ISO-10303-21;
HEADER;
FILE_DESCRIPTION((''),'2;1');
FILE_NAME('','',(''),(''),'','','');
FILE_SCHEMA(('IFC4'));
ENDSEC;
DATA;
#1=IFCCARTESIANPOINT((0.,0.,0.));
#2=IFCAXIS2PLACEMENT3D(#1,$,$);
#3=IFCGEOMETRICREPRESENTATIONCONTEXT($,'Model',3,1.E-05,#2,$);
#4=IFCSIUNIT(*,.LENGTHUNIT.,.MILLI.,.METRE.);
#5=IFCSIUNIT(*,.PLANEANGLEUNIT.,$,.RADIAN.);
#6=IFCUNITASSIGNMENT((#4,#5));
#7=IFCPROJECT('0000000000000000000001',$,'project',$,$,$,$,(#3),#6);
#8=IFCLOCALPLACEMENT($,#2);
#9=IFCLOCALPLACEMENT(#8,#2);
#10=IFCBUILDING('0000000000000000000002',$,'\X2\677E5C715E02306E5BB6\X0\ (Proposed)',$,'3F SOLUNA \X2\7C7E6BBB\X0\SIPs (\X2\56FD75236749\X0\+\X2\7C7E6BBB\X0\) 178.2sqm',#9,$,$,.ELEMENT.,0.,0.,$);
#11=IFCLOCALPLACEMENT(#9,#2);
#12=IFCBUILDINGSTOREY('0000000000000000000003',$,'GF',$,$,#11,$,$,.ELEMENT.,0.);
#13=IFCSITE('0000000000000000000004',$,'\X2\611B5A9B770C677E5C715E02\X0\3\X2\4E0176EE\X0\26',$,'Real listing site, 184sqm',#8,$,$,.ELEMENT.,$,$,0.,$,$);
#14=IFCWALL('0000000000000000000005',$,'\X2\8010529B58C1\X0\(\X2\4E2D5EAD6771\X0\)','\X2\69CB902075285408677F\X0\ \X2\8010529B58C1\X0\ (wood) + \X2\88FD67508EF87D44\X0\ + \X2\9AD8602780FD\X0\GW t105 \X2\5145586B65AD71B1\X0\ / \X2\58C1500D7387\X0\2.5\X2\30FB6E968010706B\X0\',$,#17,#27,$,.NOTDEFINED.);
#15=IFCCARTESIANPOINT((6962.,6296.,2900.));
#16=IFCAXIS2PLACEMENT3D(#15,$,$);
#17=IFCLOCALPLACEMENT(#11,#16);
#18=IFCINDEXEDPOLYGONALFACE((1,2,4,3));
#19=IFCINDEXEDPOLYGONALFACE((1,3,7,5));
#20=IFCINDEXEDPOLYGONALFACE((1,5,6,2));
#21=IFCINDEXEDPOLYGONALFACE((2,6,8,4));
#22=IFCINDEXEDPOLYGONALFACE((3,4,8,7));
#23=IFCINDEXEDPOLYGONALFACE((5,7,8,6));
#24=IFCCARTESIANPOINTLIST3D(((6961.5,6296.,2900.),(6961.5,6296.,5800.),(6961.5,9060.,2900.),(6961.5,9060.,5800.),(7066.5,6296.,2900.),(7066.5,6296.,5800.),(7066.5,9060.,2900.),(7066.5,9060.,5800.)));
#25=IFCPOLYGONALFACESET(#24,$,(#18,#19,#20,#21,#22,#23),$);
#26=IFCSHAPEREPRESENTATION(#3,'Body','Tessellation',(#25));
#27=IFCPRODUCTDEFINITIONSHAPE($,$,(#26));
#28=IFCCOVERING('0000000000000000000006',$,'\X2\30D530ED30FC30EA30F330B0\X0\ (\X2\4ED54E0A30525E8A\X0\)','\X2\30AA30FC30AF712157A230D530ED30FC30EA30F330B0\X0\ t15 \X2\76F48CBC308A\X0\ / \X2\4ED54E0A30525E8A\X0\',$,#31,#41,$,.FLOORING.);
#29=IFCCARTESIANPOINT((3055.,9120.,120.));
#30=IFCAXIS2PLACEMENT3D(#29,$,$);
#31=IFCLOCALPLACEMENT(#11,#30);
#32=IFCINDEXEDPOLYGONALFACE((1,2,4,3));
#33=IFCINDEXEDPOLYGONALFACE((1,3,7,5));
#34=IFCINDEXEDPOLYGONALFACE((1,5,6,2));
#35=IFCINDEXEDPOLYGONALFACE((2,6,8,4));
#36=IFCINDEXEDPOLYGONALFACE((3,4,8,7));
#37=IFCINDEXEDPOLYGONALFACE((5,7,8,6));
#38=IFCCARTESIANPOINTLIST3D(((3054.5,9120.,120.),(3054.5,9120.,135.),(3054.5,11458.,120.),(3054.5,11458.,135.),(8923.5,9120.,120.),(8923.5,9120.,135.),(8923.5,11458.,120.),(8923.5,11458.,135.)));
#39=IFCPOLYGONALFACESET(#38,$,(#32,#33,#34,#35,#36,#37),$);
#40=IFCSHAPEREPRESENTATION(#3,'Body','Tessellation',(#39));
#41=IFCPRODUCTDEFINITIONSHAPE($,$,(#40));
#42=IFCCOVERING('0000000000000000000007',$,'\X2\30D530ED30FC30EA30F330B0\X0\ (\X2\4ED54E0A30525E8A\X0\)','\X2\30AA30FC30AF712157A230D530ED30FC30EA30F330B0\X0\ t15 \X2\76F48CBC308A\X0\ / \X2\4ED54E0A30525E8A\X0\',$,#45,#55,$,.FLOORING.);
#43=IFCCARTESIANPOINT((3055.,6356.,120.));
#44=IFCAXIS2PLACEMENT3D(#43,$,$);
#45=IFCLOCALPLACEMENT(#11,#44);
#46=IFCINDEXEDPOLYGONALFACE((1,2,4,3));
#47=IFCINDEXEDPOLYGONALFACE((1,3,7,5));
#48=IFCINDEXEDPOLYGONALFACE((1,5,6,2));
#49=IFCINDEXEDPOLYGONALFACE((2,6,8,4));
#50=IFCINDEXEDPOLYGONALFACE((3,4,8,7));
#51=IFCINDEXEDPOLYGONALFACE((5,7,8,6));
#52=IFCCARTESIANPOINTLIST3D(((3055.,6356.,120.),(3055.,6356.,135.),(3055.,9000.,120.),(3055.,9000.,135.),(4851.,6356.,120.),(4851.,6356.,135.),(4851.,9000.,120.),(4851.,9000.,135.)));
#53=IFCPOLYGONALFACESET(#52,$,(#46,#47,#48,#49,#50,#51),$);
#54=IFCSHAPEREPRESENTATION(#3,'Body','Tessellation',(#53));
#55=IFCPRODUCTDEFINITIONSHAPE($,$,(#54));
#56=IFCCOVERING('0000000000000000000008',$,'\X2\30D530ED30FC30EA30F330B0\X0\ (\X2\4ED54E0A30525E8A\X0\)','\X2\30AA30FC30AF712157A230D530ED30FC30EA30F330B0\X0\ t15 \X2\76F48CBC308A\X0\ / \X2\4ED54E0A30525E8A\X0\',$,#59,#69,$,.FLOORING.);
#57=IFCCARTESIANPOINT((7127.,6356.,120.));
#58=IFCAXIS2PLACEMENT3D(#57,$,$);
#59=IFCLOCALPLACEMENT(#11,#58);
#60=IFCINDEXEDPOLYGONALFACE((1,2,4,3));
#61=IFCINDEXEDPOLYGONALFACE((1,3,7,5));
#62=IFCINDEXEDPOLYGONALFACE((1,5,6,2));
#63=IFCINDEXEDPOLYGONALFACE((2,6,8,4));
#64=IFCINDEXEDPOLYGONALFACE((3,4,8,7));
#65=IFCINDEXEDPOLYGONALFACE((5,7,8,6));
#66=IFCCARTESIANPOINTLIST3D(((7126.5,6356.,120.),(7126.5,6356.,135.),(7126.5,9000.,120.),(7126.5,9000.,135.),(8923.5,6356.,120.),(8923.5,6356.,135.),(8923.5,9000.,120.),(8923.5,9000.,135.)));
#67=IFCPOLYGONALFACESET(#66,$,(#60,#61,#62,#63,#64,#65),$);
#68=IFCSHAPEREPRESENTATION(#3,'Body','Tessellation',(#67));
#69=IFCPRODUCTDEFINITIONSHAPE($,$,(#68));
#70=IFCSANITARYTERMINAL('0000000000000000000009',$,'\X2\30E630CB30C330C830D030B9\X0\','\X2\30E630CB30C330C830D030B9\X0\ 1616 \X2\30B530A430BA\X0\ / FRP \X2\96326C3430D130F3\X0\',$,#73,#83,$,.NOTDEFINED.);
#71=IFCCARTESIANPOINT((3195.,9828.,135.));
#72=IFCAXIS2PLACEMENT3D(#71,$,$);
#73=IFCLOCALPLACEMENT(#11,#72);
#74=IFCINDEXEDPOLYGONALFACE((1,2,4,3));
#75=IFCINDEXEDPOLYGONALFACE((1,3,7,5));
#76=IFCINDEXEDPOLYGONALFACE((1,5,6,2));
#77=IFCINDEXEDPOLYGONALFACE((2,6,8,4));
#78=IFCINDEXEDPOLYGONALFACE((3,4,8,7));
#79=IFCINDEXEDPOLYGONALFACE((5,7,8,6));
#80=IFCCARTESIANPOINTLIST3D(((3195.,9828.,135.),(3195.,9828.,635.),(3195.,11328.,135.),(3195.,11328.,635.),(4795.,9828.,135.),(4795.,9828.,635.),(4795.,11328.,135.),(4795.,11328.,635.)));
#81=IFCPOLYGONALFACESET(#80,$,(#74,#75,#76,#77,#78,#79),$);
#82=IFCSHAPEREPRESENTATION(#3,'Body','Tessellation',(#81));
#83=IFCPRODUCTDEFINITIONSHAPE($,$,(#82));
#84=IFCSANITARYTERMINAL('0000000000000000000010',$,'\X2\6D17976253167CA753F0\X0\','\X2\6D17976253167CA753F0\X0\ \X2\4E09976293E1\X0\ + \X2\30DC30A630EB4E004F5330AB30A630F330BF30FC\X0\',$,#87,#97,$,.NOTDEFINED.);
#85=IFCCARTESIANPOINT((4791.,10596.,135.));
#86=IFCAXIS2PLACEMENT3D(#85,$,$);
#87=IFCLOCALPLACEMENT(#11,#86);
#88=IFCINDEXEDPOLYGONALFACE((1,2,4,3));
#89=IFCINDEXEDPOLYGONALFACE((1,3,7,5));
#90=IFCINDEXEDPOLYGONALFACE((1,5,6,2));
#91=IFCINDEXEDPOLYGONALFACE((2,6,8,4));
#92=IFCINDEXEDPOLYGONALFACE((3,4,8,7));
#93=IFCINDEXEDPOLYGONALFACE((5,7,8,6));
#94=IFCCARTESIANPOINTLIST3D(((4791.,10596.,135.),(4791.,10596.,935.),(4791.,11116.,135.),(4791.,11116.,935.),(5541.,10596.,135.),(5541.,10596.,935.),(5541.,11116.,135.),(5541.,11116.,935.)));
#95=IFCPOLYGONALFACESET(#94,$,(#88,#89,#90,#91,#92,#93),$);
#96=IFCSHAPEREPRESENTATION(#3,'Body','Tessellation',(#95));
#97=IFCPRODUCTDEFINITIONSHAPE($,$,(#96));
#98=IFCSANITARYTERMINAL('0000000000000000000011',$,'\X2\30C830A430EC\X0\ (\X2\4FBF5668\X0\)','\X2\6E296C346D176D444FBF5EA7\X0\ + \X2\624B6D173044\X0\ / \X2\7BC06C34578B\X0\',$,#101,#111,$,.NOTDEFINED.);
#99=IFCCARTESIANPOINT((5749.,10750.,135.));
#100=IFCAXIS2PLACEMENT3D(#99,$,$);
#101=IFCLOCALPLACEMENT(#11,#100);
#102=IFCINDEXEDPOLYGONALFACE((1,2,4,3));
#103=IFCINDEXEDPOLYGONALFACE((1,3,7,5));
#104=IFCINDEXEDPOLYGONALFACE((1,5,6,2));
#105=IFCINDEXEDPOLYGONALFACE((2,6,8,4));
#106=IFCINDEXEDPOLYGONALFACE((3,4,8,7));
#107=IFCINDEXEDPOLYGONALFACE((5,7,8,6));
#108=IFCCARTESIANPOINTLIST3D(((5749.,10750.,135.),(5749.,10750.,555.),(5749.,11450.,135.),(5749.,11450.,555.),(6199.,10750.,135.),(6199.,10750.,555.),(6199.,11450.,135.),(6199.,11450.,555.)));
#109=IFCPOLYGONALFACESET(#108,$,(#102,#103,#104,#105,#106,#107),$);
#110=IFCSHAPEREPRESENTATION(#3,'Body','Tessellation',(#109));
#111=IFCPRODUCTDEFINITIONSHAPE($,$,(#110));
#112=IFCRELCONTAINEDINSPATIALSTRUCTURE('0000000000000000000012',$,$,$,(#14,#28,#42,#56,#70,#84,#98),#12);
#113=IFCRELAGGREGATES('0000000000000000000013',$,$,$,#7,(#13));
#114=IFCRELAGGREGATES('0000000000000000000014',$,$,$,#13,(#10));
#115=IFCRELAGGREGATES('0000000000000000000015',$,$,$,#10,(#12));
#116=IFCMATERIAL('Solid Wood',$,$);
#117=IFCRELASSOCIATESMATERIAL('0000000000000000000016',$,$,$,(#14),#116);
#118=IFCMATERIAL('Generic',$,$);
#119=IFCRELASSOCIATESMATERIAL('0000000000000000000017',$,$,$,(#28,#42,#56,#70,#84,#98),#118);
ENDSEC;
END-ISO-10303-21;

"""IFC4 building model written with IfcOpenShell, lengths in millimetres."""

from ifc_helpers import new_model, si_unit, frame, frame_2d, origin, place, context, project, spatial, rectangle, extrude, material, element, save


model = new_model("IFC4")

# Units and contexts
model_context = context("Model", 3, precision=1e-05, world=origin())
ifc_project = project(units=[si_unit("LENGTHUNIT", "METRE", prefix="MILLI"), si_unit("PLANEANGLEUNIT", "RADIAN")], contexts=[model_context])

# Site, building, storey
site_placement = place(None, origin())
site = spatial("IfcSite", under=ifc_project, at=site_placement, Name="愛媛県松山市3丁目26", ObjectType="Real listing site, 184sqm", CompositionType="ELEMENT", RefElevation=0.0)
building_placement = place(site_placement, origin())
building = spatial("IfcBuilding", under=site, at=building_placement, Name="松山市の家 (Proposed)", ObjectType="3F SOLUNA 籾殻SIPs (国産杉+籾殻) 178.2sqm", CompositionType="ELEMENT", ElevationOfRefHeight=0.0, ElevationOfTerrain=0.0)
storey_placement = place(building_placement, origin())
storey = spatial("IfcBuildingStorey", under=building, at=storey_placement, Name="GF", CompositionType="ELEMENT", Elevation=0.0)

# Shared definitions
ifc_material_1 = material(Name="Solid Wood")

# Wall
wall_1_placement = place(storey_placement, frame((6962.0, 6296.0, 2900.0)))
element("IfcWall", 1, at=wall_1_placement, inside=storey, material=ifc_material_1, Name="耐力壁(中庭東)", Description="構造用合板 耐力壁 (wood) + 製材軸組 + 高性能GW t105 充填断熱 / 壁倍率2.5・準耐火", PredefinedType="NOTDEFINED", context=model_context, shape_type="SweptSolid", body=[
    extrude(rectangle(XDim=105.0, YDim=2764.0, at=frame_2d((52.0, 1382.0))), frame((6962.0, 6296.0, 2900.0)), (0.0, 0.0, 1.0), 2900.0),
])

# Coverings
ifc_material_2 = material(Name="Generic")
covering_1_placement = place(storey_placement, frame((3055.0, 9120.0, 120.0)))
element("IfcCovering", 2, at=covering_1_placement, inside=storey, material=ifc_material_2, Name="フローリング (仕上げ床)", Description="オーク無垢フローリング t15 直貼り / 仕上げ床", PredefinedType="FLOORING", context=model_context, shape_type="SweptSolid", body=[
    extrude(rectangle(XDim=5869.0, YDim=2338.0, at=frame_2d((2934.0, 1169.0))), frame((3055.0, 9120.0, 120.0)), (0.0, 0.0, 1.0), 15.0),
])
covering_2_placement = place(storey_placement, frame((3055.0, 6356.0, 120.0)))
element("IfcCovering", 3, at=covering_2_placement, inside=storey, material=ifc_material_2, Name="フローリング (仕上げ床)", Description="オーク無垢フローリング t15 直貼り / 仕上げ床", PredefinedType="FLOORING", context=model_context, shape_type="SweptSolid", body=[
    extrude(rectangle(XDim=1796.0, YDim=2644.0, at=frame_2d((898.0, 1322.0))), frame((3055.0, 6356.0, 120.0)), (0.0, 0.0, 1.0), 15.0),
])
covering_3_placement = place(storey_placement, frame((7127.0, 6356.0, 120.0)))
element("IfcCovering", 4, at=covering_3_placement, inside=storey, material=ifc_material_2, Name="フローリング (仕上げ床)", Description="オーク無垢フローリング t15 直貼り / 仕上げ床", PredefinedType="FLOORING", context=model_context, shape_type="SweptSolid", body=[
    extrude(rectangle(XDim=1797.0, YDim=2644.0, at=frame_2d((898.0, 1322.0))), frame((7127.0, 6356.0, 120.0)), (0.0, 0.0, 1.0), 15.0),
])

# Sanitary terminals
sanitary_terminal_1_placement = place(storey_placement, frame((3195.0, 9828.0, 135.0)))
element("IfcSanitaryTerminal", 5, at=sanitary_terminal_1_placement, inside=storey, material=ifc_material_2, Name="ユニットバス", Description="ユニットバス 1616 サイズ / FRP 防水パン", PredefinedType="NOTDEFINED", context=model_context, shape_type="SweptSolid", body=[
    extrude(rectangle(XDim=1600.0, YDim=1500.0, at=frame_2d((800.0, 750.0))), frame((3195.0, 9828.0, 135.0)), (0.0, 0.0, 1.0), 500.0),
])
sanitary_terminal_2_placement = place(storey_placement, frame((4791.0, 10596.0, 135.0)))
element("IfcSanitaryTerminal", 6, at=sanitary_terminal_2_placement, inside=storey, material=ifc_material_2, Name="洗面化粧台", Description="洗面化粧台 三面鏡 + ボウル一体カウンター", PredefinedType="NOTDEFINED", context=model_context, shape_type="SweptSolid", body=[
    extrude(rectangle(XDim=750.0, YDim=520.0, at=frame_2d((375.0, 260.0))), frame((4791.0, 10596.0, 135.0)), (0.0, 0.0, 1.0), 800.0),
])
sanitary_terminal_3_placement = place(storey_placement, frame((5749.0, 10750.0, 135.0)))
element("IfcSanitaryTerminal", 7, at=sanitary_terminal_3_placement, inside=storey, material=ifc_material_2, Name="トイレ (便器)", Description="温水洗浄便座 + 手洗い / 節水型", PredefinedType="NOTDEFINED", context=model_context, shape_type="SweptSolid", body=[
    extrude(rectangle(XDim=450.0, YDim=700.0, at=frame_2d((225.0, 350.0))), frame((5749.0, 10750.0, 135.0)), (0.0, 0.0, 1.0), 420.0),
])

save(model, "model.ifc")
